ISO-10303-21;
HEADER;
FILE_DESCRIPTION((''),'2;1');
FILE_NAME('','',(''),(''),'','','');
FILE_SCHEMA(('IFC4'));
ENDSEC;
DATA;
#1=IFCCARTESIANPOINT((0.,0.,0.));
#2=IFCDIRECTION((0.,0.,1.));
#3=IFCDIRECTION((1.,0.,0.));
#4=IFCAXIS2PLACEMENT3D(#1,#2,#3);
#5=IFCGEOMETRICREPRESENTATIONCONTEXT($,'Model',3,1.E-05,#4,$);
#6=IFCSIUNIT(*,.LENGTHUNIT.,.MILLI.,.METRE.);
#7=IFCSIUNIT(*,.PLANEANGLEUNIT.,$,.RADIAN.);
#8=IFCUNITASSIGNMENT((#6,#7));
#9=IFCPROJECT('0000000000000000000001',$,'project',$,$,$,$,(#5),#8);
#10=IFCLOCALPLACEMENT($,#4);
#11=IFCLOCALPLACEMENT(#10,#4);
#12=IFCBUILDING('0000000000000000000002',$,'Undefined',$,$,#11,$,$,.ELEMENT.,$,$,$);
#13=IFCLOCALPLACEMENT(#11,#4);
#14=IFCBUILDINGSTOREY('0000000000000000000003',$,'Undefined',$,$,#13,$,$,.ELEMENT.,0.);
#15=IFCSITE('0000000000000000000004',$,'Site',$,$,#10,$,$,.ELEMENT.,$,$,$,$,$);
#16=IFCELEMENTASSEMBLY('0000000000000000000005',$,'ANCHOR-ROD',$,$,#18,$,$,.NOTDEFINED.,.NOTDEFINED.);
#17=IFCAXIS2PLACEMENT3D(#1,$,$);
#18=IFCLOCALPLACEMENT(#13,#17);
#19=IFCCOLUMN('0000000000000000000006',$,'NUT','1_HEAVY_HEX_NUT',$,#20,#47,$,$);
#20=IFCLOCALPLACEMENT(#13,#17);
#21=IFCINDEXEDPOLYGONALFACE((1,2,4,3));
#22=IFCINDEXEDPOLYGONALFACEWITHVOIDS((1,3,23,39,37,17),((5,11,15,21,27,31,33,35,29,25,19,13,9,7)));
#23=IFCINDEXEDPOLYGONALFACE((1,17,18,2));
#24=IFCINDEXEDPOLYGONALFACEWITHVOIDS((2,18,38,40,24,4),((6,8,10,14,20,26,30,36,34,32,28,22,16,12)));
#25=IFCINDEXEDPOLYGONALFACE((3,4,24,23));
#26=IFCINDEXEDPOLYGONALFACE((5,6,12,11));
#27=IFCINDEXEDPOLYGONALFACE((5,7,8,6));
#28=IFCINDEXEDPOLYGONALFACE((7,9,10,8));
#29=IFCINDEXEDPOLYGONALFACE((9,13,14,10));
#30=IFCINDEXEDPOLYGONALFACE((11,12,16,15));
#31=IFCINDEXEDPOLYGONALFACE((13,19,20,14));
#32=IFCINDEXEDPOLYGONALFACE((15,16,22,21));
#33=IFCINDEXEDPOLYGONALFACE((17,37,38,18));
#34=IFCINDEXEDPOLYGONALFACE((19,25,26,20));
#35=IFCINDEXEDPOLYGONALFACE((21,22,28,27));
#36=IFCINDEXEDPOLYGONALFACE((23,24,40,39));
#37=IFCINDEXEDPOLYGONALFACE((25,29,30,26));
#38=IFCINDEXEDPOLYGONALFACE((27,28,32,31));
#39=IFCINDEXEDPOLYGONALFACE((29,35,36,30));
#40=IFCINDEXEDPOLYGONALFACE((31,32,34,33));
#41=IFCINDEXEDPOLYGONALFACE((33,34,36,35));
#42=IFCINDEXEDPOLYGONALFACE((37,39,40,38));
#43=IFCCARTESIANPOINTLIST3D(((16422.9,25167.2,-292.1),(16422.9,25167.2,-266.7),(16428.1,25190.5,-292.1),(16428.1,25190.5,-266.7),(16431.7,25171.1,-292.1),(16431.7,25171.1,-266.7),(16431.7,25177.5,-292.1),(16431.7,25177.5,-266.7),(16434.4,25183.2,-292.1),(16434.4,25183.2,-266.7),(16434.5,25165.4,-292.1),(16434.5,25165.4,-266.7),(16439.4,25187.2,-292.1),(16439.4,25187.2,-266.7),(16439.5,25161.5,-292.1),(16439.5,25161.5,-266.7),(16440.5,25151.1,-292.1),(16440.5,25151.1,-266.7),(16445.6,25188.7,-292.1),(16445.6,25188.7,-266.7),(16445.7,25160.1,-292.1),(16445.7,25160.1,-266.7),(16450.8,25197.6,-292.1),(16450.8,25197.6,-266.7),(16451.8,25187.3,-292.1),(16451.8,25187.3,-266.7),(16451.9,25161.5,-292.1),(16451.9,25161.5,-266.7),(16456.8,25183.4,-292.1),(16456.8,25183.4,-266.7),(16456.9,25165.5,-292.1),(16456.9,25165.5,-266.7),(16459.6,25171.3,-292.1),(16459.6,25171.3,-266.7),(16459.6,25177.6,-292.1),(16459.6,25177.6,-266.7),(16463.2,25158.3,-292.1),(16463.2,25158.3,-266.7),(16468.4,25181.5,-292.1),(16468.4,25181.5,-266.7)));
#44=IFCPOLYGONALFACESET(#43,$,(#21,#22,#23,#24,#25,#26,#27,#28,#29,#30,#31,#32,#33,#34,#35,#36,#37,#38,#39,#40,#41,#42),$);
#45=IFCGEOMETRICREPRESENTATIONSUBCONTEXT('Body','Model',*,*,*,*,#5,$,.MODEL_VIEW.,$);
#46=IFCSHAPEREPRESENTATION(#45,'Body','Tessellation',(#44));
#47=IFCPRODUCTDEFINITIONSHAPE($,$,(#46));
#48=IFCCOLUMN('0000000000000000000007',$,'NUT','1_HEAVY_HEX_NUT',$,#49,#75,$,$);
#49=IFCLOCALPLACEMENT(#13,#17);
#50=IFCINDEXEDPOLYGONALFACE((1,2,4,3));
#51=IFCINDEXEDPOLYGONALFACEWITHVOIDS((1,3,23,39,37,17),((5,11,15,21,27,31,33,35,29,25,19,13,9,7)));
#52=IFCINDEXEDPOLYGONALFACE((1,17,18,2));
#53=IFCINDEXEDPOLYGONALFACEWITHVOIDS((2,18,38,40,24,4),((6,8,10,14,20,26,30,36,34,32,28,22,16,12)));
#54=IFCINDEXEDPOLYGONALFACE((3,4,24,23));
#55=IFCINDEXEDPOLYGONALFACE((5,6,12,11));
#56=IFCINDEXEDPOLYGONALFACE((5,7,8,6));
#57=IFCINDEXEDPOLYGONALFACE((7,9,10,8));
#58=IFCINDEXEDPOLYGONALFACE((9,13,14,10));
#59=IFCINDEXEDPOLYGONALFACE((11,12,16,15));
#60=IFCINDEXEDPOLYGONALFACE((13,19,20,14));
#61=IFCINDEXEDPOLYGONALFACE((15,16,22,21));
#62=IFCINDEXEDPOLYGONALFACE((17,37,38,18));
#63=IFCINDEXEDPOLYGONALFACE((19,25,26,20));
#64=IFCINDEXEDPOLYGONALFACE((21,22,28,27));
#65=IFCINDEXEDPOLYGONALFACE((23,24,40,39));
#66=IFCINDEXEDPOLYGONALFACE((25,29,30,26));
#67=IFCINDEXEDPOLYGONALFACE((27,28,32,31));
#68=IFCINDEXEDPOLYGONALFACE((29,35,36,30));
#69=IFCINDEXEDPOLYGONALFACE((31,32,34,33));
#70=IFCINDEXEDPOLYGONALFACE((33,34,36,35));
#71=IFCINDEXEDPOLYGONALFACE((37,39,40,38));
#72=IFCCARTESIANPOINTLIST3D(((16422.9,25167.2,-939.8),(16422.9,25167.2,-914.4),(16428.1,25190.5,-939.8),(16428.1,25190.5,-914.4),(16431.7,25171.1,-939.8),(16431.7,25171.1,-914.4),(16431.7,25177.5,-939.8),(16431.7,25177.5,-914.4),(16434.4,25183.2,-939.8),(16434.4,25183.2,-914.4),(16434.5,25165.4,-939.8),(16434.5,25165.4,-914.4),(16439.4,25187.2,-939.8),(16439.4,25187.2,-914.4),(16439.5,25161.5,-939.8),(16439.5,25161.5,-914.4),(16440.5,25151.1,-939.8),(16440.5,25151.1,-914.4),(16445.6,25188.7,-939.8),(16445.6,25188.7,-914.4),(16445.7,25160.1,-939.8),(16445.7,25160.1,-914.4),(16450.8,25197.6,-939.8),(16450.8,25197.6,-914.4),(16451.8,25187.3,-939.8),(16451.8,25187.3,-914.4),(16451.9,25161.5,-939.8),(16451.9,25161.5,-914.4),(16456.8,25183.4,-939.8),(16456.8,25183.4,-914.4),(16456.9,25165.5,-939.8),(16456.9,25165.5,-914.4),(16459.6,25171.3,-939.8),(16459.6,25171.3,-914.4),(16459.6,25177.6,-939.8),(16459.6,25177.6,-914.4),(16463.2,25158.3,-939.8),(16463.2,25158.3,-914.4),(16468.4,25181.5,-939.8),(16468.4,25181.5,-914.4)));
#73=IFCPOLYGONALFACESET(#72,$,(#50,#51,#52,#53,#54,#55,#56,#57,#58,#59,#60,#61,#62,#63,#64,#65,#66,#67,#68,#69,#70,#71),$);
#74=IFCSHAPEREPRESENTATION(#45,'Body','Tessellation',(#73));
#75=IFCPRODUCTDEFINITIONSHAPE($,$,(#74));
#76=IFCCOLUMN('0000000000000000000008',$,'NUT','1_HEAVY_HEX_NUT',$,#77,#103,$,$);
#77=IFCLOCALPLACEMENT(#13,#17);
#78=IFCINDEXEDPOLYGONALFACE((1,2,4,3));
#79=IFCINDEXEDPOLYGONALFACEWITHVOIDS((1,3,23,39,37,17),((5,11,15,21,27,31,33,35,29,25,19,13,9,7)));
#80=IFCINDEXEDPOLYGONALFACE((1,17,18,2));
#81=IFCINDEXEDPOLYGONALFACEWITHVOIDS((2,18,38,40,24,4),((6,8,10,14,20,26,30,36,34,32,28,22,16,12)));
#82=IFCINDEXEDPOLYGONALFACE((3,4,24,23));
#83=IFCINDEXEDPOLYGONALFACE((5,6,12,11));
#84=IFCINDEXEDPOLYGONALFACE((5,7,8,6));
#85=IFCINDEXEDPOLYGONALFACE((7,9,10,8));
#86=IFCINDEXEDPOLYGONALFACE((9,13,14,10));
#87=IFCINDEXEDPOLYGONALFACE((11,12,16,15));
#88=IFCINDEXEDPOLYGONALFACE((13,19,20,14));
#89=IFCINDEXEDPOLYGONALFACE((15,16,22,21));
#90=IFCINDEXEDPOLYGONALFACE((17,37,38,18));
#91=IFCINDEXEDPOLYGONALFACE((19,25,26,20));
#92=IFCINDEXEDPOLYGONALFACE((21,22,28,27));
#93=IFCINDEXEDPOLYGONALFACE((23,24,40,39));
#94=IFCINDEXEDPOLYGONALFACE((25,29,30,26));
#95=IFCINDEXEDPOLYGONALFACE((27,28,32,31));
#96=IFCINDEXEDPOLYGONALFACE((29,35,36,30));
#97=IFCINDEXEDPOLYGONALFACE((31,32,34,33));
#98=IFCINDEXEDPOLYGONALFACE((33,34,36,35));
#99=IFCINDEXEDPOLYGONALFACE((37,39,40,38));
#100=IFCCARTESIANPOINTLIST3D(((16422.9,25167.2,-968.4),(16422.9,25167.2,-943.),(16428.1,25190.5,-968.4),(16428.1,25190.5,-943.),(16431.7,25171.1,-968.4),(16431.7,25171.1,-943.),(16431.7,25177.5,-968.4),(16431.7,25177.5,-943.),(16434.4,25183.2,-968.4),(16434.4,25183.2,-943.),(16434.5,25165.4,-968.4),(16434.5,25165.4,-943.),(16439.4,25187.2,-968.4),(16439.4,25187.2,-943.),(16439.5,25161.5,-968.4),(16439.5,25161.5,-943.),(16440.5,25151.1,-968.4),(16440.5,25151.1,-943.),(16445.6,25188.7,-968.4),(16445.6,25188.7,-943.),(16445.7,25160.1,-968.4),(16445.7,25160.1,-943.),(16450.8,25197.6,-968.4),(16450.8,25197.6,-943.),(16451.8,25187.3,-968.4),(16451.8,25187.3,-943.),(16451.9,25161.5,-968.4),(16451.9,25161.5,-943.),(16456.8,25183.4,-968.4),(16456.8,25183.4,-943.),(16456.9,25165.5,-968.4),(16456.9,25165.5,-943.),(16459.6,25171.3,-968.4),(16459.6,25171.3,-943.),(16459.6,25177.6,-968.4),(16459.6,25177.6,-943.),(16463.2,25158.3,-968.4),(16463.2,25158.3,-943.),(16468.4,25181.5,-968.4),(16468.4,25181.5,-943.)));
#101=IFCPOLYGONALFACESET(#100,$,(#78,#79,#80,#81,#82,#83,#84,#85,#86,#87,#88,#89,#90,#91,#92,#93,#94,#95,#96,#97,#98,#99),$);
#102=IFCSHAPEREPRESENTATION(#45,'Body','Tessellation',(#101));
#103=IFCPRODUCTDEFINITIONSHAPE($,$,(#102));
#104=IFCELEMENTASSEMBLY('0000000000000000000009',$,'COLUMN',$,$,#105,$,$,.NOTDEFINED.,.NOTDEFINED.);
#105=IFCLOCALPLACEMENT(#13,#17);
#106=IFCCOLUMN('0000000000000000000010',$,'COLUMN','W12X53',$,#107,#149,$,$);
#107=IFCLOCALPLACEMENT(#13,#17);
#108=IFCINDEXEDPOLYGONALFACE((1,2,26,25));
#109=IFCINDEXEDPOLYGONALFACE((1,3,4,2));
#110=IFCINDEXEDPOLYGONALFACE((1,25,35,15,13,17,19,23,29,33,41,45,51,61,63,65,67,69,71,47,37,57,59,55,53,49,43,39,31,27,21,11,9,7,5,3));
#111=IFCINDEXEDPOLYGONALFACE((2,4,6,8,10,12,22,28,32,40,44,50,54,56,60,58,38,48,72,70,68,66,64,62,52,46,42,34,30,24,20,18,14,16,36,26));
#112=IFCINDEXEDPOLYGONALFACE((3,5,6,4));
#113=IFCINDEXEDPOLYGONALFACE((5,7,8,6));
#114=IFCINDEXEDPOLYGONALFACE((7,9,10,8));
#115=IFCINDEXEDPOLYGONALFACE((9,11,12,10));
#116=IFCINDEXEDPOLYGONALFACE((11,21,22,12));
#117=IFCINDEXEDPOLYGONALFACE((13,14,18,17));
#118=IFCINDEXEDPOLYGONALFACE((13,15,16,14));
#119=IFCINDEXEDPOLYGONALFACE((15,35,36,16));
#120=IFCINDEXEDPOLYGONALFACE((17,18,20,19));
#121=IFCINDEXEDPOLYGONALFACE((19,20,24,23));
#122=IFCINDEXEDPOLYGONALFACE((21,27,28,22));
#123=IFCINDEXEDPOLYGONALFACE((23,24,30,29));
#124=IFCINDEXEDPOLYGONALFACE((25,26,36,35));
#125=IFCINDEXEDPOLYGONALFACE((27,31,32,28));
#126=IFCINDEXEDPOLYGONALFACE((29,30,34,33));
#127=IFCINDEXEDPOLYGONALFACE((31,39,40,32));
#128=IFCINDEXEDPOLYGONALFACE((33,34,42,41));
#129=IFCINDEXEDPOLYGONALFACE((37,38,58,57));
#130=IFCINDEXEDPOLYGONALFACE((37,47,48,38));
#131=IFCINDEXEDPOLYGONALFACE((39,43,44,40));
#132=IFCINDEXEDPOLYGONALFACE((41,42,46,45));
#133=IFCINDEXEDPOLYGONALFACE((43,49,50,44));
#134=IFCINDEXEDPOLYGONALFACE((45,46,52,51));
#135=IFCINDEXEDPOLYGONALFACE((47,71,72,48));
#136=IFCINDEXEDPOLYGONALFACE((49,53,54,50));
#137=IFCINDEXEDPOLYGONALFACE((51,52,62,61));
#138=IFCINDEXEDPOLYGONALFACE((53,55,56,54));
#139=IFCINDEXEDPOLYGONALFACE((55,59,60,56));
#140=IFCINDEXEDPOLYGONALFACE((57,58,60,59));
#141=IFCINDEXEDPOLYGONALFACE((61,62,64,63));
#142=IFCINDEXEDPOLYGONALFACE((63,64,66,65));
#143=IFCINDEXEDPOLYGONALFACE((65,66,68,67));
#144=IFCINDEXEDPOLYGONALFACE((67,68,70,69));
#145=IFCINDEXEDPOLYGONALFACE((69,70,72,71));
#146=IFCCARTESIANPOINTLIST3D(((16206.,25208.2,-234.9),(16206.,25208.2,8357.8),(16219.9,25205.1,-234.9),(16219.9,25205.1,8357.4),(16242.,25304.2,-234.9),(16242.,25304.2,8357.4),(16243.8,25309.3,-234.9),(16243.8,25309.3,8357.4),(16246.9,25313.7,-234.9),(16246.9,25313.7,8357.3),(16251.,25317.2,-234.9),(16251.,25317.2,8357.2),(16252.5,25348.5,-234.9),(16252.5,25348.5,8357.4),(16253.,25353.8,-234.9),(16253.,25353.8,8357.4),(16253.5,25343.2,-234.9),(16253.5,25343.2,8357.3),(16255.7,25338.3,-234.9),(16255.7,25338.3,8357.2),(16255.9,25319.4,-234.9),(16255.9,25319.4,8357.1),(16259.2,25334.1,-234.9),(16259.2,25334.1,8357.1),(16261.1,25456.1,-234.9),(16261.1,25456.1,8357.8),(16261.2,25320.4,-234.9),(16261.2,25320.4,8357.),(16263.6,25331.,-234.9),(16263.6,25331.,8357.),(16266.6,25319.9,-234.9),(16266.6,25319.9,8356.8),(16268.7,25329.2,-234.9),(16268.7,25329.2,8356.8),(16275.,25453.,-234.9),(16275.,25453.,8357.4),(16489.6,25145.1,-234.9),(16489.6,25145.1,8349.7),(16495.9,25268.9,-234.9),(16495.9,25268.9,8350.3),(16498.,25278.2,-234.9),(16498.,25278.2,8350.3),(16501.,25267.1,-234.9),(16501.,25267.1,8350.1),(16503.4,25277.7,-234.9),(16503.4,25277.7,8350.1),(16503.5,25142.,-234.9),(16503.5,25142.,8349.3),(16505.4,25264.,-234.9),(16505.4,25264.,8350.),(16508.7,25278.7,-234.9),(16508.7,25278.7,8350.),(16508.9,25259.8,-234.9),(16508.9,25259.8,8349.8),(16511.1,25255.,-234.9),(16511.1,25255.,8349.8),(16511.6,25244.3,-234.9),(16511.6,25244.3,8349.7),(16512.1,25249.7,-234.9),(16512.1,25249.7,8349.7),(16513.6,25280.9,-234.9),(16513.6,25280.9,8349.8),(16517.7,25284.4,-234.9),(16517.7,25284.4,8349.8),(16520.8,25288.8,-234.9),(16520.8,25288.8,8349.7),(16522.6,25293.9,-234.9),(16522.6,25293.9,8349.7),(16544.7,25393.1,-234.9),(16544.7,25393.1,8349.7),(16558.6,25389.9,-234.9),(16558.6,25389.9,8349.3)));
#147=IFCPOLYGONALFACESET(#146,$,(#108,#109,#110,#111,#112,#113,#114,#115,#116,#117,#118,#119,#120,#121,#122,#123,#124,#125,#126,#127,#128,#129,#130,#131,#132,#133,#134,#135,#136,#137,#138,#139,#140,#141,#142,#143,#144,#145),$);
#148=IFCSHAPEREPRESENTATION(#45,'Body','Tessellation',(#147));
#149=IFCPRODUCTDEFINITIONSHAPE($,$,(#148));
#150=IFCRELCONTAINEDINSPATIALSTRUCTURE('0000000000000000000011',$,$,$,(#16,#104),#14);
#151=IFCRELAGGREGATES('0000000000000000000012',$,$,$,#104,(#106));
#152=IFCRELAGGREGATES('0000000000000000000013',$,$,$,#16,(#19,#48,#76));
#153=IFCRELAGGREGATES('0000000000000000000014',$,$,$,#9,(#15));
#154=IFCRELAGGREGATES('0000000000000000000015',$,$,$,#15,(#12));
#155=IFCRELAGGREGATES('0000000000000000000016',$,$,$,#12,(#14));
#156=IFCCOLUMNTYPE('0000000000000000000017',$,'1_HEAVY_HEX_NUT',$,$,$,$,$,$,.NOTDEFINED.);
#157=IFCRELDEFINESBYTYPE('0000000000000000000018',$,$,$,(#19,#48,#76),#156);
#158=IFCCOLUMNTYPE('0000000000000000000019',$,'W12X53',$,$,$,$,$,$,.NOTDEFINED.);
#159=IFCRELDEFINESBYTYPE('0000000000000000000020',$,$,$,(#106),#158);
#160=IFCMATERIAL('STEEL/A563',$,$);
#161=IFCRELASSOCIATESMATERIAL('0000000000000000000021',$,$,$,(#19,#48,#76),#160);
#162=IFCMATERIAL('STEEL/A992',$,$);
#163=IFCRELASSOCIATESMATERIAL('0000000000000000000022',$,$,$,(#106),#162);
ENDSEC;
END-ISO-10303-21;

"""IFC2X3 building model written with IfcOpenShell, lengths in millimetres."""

from ifc_helpers import new_model, si_unit, frame, origin_with_axes, origin_2d_with_axis, place, context, subcontext, project, spatial, polyline, i_section, outline, extrude, clip, halfspace, material, type_object, element, aggregate, save


model = new_model("IFC2X3")

# Units and contexts
model_context = context("Model", 3, precision=1e-05, world=origin_with_axes())
body_context = subcontext(model_context, "Body", "Model", "MODEL_VIEW")
ifc_project = project(units=[si_unit("LENGTHUNIT", "METRE", prefix="MILLI"), si_unit("PLANEANGLEUNIT", "RADIAN")], contexts=[model_context])

# Site, building, storey
site_placement = place(None, origin_with_axes())
site = spatial("IfcSite", under=ifc_project, at=site_placement, Name="Site", CompositionType="ELEMENT")
building_placement = place(site_placement, origin_with_axes())
building = spatial("IfcBuilding", under=site, at=building_placement, Name="Undefined", CompositionType="ELEMENT")
storey_placement = place(building_placement, origin_with_axes())
storey = spatial("IfcBuildingStorey", under=building, at=storey_placement, Name="Undefined", CompositionType="ELEMENT", Elevation=0.0)

# Element assembly, columns
ifc_material_1 = material(Name="STEEL/A563")
column_type_1 = type_object("IfcColumnType", Name="1_HEAVY_HEX_NUT", PredefinedType="NOTDEFINED")
assembly_1_placement = place(storey_placement, origin_with_axes())
assembly_1 = element("IfcElementAssembly", 1, at=assembly_1_placement, inside=storey, Name="ANCHOR-ROD", AssemblyPlace="NOTDEFINED", PredefinedType="NOTDEFINED")
column_1_placement = place(assembly_1_placement, frame((16445.6, 25174.4, -266.7), z_axis=(0.0, 0.0, -1.0), x_axis=(0.976162, -0.217044, 0.0)))
column_1 = element("IfcColumn", 2, at=column_1_placement, type_object=column_type_1, material=ifc_material_1, Name="NUT", Description="1_HEAVY_HEX_NUT", context=body_context, shape_type="SweptSolid", body=[
    extrude(outline(polyline([(-11.9, -20.6), (-23.8, 0.0), (-11.9, 20.6), (11.9, 20.6), (23.8, 0.0), (11.9, -20.6), (-11.9, -20.6)]), holes=[polyline([(11.2, 8.9), (6.2, 12.9), (0.0, 14.3), (-6.2, 12.9), (-11.2, 8.9), (-13.9, 3.2), (-13.9, -3.2), (-11.2, -8.9), (-6.2, -12.9), (0.0, -14.3), (6.2, -12.9), (11.2, -8.9), (13.9, -3.2), (13.9, 3.2), (11.2, 8.9)])]), frame((0.0, 0.0, 25.4), z_axis=(0.0, 0.0, -1.0), x_axis=(0.0, 1.0, 0.0)), (0.0, 0.0, 1.0), 25.4),
])
column_2_placement = place(assembly_1_placement, frame((16445.6, 25174.4, -914.4), z_axis=(0.0, 0.0, -1.0), x_axis=(0.976162, -0.217044, 0.0)))
column_2 = element("IfcColumn", 3, at=column_2_placement, type_object=column_type_1, material=ifc_material_1, Name="NUT", Description="1_HEAVY_HEX_NUT", context=body_context, shape_type="SweptSolid", body=[
    extrude(outline(polyline([(-11.9, -20.6), (-23.8, 0.0), (-11.9, 20.6), (11.9, 20.6), (23.8, 0.0), (11.9, -20.6), (-11.9, -20.6)]), holes=[polyline([(11.2, 8.9), (6.2, 12.9), (0.0, 14.3), (-6.2, 12.9), (-11.2, 8.9), (-13.9, 3.2), (-13.9, -3.2), (-11.2, -8.9), (-6.2, -12.9), (0.0, -14.3), (6.2, -12.9), (11.2, -8.9), (13.9, -3.2), (13.9, 3.2), (11.2, 8.9)])]), frame((0.0, 0.0, 25.4), z_axis=(0.0, 0.0, -1.0), x_axis=(0.0, 1.0, 0.0)), (0.0, 0.0, 1.0), 25.4),
])
column_3_placement = place(assembly_1_placement, frame((16445.6, 25174.4, -943.0), z_axis=(0.0, 0.0, -1.0), x_axis=(0.976162, -0.217044, 0.0)))
column_3 = element("IfcColumn", 4, at=column_3_placement, type_object=column_type_1, material=ifc_material_1, Name="NUT", Description="1_HEAVY_HEX_NUT", context=body_context, shape_type="SweptSolid", body=[
    extrude(outline(polyline([(-11.9, -20.6), (-23.8, 0.0), (-11.9, 20.6), (11.9, 20.6), (23.8, 0.0), (11.9, -20.6), (-11.9, -20.6)]), holes=[polyline([(11.2, 8.9), (6.2, 12.9), (0.0, 14.3), (-6.2, 12.9), (-11.2, 8.9), (-13.9, 3.2), (-13.9, -3.2), (-11.2, -8.9), (-6.2, -12.9), (0.0, -14.3), (6.2, -12.9), (11.2, -8.9), (13.9, -3.2), (13.9, 3.2), (11.2, 8.9)])]), frame((0.0, 0.0, 25.4), z_axis=(0.0, 0.0, -1.0), x_axis=(0.0, 1.0, 0.0)), (0.0, 0.0, 1.0), 25.4),
])

# Element assembly, column
assembly_2_placement = place(storey_placement, origin_with_axes())
assembly_2 = element("IfcElementAssembly", 5, at=assembly_2_placement, inside=storey, Name="COLUMN", AssemblyPlace="NOTDEFINED", PredefinedType="NOTDEFINED")
ifc_material_2 = material(Name="STEEL/A992")
column_type_2 = type_object("IfcColumnType", Name="W12X53", PredefinedType="NOTDEFINED")
column_4_placement = place(assembly_2_placement, frame((16382.3, 25299.1, -304.8), z_axis=(0.0, 0.0, 1.0), x_axis=(0.976162, -0.217044, 0.0)))
column_4 = element("IfcColumn", 6, at=column_4_placement, type_object=column_type_2, material=ifc_material_2, Name="COLUMN", Description="W12X53", context=body_context, shape_type="Clipping", body=[
    clip(clip(extrude(i_section(OverallWidth=254.0, OverallDepth=304.8, WebThickness=9.5, FlangeThickness=14.3, FilletRadius=20.6, at=origin_2d_with_axis()), frame((0.0, 0.0, 9024.7), z_axis=(0.0, 0.0, -1.0), x_axis=(0.0, 1.0, 0.0)), (0.0, 0.0, 1.0), 9024.6), halfspace(frame((999.6, 0.0, 8630.3), z_axis=(-0.028012, 0.0, -0.999608), x_axis=(0.0, 1.0, 0.0)), True)), halfspace(frame((-152.4, 0.0, 69.9), z_axis=(0.0, 0.0, 1.0), x_axis=(0.0, 1.0, 0.0)), True)),
])
aggregate(assembly_2, [column_4])

aggregate(assembly_1, [column_1, column_2, column_3])

save(model, "model.ifc")
